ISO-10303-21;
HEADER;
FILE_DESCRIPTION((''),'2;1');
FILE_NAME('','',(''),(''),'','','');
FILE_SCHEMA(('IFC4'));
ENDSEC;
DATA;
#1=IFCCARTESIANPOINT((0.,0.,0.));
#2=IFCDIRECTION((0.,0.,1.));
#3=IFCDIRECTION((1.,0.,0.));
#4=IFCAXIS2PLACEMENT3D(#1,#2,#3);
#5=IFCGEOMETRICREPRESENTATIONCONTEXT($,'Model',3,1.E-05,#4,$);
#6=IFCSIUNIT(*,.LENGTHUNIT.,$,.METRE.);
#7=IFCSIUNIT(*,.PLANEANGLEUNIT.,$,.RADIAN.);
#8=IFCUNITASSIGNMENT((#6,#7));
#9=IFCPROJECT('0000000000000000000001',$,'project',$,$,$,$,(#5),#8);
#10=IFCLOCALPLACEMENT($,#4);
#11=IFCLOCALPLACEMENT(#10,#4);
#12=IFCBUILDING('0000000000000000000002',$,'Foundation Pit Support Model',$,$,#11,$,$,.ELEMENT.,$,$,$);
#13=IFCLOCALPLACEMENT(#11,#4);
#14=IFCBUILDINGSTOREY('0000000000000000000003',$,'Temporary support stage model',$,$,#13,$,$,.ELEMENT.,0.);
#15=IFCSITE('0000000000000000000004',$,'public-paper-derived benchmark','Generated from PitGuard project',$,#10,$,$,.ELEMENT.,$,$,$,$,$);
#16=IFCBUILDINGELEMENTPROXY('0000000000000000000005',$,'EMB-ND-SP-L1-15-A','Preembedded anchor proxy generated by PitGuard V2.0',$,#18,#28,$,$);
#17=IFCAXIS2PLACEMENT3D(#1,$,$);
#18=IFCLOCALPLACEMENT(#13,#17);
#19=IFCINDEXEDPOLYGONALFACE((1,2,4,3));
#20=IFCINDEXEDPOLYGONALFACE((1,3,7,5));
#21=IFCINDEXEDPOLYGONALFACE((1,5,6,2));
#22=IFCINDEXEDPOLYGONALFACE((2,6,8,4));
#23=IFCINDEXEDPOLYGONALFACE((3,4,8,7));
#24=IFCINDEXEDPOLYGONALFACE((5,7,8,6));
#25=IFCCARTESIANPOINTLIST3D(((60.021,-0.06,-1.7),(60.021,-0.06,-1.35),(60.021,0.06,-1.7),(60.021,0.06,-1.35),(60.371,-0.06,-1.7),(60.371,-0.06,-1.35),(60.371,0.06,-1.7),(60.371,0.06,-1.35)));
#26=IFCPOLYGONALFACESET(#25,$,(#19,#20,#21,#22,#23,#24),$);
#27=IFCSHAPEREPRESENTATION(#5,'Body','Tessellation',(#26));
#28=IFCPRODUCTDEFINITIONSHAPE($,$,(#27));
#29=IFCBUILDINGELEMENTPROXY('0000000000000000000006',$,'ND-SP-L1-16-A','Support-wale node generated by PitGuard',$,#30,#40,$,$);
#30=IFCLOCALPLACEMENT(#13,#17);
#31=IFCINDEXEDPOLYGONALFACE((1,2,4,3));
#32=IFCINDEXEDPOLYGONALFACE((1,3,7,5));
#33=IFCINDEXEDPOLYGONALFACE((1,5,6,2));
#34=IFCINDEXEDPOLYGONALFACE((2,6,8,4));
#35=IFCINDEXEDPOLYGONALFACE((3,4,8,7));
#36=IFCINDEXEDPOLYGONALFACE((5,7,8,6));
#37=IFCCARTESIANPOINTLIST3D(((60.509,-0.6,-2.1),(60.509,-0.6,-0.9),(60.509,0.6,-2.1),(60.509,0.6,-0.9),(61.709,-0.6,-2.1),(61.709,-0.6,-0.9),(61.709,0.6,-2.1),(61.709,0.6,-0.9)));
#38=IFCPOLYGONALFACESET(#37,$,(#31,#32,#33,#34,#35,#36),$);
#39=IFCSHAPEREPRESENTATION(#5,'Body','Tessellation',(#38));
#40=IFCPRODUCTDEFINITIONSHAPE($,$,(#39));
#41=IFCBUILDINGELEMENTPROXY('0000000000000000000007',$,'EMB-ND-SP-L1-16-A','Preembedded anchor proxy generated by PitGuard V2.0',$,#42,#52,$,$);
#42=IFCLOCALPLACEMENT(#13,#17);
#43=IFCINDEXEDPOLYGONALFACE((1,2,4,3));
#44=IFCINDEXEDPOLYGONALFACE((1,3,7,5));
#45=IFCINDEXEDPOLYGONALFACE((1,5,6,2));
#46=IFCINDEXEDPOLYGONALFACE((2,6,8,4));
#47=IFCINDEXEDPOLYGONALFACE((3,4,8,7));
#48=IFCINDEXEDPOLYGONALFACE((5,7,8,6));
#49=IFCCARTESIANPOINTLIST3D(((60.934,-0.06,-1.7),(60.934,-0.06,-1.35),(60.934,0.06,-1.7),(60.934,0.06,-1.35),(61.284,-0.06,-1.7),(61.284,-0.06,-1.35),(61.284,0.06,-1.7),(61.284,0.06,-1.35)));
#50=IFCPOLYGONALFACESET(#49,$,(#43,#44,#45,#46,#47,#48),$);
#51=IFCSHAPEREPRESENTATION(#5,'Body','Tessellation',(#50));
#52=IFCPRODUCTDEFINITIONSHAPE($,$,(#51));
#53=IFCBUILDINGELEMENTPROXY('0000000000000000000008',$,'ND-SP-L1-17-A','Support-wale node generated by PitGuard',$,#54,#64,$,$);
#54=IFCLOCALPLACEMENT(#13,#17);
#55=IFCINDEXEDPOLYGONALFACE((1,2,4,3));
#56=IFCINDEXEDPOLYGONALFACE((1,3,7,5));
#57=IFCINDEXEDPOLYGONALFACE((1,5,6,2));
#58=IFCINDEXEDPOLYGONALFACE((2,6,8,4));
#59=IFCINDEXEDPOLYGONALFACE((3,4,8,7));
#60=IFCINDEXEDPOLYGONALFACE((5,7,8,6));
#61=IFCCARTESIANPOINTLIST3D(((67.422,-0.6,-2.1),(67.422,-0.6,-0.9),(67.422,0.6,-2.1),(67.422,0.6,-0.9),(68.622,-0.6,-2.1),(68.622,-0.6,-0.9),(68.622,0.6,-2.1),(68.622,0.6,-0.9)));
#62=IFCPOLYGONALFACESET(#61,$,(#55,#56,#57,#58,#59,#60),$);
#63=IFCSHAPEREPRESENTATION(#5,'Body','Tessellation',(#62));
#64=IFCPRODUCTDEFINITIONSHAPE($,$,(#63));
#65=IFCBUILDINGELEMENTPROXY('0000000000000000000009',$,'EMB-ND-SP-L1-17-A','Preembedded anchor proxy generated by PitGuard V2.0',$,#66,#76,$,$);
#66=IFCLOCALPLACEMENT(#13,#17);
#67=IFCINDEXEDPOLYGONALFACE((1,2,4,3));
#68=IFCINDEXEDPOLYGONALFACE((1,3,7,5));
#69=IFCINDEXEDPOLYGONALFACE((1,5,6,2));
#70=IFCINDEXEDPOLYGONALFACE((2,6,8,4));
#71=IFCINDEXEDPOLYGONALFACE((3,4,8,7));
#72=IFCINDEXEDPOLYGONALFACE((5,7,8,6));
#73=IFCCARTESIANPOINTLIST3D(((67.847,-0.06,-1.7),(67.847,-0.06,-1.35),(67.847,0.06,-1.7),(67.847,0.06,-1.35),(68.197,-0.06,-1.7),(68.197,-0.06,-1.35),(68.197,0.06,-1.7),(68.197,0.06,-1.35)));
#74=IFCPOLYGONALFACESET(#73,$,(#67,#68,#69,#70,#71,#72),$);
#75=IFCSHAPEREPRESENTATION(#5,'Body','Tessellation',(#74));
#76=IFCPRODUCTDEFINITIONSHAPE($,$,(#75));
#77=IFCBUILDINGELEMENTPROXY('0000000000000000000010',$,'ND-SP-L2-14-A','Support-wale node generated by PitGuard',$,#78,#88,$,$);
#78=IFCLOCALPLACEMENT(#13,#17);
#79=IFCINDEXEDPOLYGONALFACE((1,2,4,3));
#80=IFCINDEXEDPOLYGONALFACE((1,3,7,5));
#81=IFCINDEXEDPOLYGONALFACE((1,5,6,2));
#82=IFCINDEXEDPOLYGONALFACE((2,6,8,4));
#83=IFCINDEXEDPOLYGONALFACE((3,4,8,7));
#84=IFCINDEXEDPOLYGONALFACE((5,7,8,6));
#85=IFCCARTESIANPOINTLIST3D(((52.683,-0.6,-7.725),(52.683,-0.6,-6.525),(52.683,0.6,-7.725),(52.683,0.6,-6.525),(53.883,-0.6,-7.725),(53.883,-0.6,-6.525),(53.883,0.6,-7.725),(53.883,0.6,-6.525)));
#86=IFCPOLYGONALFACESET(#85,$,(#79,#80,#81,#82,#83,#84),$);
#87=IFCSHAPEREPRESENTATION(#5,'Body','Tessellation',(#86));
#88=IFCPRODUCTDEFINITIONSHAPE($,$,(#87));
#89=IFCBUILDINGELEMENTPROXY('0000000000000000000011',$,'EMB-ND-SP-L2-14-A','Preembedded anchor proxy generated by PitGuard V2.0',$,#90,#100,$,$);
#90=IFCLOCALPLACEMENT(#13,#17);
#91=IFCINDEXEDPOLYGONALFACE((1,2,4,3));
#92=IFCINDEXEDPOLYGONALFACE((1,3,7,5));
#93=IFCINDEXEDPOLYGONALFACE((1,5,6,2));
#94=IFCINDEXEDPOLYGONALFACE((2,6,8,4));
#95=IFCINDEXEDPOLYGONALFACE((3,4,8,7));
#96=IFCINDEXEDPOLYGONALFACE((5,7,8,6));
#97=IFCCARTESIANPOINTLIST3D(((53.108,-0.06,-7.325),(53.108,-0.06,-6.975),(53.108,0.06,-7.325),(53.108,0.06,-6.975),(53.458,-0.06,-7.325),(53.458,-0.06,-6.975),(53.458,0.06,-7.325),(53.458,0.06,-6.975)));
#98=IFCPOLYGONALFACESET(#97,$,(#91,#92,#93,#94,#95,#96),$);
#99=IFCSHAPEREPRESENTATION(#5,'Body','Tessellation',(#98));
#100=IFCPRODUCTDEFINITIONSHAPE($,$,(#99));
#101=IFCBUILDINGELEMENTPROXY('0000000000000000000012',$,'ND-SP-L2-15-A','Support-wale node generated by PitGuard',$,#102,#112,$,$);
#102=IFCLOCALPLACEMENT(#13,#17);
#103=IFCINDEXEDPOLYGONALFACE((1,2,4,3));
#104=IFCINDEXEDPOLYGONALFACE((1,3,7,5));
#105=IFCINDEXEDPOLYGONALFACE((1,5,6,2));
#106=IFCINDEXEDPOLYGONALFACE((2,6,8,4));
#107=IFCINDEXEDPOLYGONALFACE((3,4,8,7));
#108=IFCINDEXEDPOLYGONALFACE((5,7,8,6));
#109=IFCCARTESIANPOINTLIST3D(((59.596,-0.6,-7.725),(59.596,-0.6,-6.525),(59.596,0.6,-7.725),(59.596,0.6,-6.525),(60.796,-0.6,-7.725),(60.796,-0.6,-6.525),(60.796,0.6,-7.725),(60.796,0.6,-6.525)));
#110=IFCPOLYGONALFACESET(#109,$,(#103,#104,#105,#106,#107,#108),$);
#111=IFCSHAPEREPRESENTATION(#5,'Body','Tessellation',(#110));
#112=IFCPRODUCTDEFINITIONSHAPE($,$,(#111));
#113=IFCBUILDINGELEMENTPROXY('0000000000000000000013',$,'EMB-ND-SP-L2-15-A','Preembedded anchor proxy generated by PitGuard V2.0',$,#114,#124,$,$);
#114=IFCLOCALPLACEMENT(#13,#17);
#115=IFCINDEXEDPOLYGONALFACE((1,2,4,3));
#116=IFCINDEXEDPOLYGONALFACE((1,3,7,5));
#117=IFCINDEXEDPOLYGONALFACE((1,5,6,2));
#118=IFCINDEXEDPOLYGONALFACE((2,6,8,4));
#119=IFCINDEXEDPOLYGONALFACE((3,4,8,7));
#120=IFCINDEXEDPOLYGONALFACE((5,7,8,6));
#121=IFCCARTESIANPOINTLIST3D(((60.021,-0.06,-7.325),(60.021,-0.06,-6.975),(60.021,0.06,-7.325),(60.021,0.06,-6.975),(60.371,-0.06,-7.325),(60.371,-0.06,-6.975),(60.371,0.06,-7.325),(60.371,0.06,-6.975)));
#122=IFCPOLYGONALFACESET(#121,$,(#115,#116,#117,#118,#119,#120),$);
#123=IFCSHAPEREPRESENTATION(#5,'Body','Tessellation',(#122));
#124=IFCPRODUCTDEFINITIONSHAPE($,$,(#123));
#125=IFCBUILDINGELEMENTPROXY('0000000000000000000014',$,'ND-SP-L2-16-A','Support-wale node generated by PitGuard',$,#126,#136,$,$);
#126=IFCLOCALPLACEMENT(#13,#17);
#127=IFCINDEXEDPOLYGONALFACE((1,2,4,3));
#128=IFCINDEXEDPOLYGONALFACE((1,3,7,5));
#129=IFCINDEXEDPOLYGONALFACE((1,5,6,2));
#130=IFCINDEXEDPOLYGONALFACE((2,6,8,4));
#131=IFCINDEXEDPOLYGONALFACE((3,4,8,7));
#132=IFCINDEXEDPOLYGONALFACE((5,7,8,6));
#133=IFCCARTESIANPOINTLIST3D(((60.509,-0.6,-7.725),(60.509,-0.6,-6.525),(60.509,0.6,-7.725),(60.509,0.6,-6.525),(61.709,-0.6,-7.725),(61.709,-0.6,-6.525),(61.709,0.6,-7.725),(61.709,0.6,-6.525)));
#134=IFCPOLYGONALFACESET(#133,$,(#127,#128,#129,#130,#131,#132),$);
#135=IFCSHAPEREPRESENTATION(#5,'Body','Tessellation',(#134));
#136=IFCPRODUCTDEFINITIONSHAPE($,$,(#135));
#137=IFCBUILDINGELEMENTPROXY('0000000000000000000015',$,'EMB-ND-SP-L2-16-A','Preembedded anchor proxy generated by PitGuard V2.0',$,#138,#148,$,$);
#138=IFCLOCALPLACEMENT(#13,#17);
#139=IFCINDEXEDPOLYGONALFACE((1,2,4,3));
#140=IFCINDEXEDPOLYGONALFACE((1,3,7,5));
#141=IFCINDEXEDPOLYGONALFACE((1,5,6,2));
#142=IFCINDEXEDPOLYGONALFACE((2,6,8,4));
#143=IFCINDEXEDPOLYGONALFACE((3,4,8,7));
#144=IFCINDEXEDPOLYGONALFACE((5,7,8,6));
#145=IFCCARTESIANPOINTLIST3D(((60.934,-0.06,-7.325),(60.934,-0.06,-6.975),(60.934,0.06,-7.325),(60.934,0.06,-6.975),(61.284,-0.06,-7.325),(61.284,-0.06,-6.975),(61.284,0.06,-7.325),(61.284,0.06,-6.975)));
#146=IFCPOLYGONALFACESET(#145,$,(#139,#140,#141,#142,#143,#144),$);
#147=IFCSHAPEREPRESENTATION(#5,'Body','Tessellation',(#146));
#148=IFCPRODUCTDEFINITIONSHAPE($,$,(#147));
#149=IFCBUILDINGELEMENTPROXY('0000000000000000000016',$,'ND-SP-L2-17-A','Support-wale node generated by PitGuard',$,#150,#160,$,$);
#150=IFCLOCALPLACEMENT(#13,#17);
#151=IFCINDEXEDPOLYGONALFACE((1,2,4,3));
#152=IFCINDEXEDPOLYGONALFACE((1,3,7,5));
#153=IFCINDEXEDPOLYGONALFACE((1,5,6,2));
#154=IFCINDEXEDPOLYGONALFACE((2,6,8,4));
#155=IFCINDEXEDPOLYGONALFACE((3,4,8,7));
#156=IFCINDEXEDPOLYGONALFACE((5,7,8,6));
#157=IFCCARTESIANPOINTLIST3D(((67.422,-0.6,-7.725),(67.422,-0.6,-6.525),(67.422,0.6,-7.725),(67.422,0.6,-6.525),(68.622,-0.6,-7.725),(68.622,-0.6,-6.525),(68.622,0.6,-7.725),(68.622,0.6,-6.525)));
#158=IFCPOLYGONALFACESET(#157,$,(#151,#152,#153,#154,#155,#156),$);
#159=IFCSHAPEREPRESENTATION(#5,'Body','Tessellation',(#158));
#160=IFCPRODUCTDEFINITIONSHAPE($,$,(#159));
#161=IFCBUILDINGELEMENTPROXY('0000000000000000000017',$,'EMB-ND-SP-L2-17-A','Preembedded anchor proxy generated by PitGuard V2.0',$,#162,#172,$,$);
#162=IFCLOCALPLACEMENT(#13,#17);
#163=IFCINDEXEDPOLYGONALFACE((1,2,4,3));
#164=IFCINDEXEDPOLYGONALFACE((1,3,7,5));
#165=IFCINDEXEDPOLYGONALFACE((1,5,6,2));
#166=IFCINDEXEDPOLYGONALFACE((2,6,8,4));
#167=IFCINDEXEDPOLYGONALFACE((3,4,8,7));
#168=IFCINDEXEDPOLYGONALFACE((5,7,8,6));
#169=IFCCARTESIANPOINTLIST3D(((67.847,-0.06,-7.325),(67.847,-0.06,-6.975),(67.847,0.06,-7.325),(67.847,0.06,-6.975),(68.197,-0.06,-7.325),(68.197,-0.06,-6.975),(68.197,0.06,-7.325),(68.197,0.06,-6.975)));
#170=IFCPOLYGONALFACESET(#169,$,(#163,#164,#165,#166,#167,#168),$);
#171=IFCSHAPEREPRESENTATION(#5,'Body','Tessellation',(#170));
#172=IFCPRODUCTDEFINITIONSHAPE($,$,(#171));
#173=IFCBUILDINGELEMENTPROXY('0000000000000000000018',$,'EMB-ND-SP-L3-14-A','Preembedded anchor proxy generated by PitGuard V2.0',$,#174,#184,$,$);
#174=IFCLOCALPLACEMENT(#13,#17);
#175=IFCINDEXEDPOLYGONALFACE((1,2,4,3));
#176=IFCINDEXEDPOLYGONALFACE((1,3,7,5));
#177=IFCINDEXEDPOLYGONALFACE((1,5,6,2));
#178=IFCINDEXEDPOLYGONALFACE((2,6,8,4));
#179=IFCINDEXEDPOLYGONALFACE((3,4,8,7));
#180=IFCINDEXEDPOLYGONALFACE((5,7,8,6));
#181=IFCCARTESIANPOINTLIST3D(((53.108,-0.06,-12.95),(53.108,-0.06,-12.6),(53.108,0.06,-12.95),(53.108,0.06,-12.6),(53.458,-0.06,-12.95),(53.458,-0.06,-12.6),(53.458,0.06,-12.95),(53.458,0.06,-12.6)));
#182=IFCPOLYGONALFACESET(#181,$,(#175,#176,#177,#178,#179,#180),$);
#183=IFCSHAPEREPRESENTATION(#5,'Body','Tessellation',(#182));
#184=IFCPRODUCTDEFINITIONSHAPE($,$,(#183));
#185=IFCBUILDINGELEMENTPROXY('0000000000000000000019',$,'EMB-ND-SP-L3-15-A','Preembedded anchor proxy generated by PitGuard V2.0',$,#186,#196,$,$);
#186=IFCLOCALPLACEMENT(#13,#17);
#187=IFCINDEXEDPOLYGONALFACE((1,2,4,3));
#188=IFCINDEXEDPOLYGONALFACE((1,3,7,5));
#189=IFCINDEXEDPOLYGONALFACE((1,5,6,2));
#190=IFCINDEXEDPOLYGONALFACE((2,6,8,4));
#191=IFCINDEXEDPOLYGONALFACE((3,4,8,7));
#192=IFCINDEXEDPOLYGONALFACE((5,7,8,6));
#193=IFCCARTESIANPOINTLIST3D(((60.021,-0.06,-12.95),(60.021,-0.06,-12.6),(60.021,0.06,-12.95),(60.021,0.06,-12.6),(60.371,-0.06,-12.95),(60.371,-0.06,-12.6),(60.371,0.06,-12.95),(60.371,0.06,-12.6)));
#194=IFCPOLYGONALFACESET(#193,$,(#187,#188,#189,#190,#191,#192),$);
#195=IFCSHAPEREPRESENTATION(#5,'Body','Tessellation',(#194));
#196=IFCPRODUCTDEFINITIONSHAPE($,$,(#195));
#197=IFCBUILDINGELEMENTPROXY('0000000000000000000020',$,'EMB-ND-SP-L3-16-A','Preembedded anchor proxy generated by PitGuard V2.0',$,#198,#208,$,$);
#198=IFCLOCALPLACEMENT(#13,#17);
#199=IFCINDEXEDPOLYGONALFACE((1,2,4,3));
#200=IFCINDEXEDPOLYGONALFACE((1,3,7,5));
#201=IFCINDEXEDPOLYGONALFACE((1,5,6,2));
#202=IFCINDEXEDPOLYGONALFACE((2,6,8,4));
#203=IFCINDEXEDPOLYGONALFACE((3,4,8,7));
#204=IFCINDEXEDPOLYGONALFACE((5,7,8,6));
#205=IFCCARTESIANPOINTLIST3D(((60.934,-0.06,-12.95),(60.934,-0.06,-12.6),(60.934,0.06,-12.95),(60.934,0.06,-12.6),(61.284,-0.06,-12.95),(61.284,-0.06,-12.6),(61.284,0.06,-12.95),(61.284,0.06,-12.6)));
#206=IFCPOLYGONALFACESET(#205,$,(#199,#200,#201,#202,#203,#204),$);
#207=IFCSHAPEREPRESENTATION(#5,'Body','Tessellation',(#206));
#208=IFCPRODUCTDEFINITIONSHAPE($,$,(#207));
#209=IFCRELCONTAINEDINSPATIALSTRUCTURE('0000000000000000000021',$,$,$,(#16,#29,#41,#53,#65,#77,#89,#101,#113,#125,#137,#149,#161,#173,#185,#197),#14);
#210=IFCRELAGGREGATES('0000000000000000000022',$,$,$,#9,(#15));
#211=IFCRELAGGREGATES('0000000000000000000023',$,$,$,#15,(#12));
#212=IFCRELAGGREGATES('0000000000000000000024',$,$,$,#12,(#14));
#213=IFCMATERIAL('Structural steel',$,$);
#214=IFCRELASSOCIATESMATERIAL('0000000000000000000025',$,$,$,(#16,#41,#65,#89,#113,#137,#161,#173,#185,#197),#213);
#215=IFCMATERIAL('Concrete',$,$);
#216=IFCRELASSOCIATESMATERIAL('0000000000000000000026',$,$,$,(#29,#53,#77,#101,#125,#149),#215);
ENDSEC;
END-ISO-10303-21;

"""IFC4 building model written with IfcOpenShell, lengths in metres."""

from ifc_helpers import new_model, si_unit, frame, origin_with_axes, origin_2d, place, context, project, spatial, rectangle, extrude, material, element, save


model = new_model("IFC4")

# Units and contexts
model_context = context("Model", 3, precision=1e-05, world=origin_with_axes())
ifc_project = project(units=[si_unit("LENGTHUNIT", "METRE"), si_unit("PLANEANGLEUNIT", "RADIAN")], contexts=[model_context])

# Site, building, storey
site_placement = place(None, origin_with_axes())
site = spatial("IfcSite", under=ifc_project, at=site_placement, Name="public-paper-derived benchmark", Description="Generated from PitGuard project", CompositionType="ELEMENT")
building_placement = place(site_placement, origin_with_axes())
building = spatial("IfcBuilding", under=site, at=building_placement, Name="Foundation Pit Support Model", CompositionType="ELEMENT")
storey_placement = place(building_placement, origin_with_axes())
storey = spatial("IfcBuildingStorey", under=building, at=storey_placement, Name="Temporary support stage model", CompositionType="ELEMENT", Elevation=0.0)

# Shared definitions
ifc_material_1 = material(Name="Concrete")

# Shared definitions
ifc_material_2 = material(Name="Structural steel")

# Building element proxies
proxy_1_placement = place(storey_placement, frame((60.196, 0.0, -1.7), z_axis=(0.0, 0.0, 1.0), x_axis=(1.0, 0.0, 0.0)))
element("IfcBuildingElementProxy", 1, at=proxy_1_placement, inside=storey, material=ifc_material_2, Name="EMB-ND-SP-L1-15-A", Description="Preembedded anchor proxy generated by PitGuard V2.0", context=model_context, shape_type="SweptSolid", body=[
    extrude(rectangle(XDim=0.35, YDim=0.12, at=origin_2d()), origin_with_axes(), (0.0, 0.0, 1.0), 0.35),
])
proxy_2_placement = place(storey_placement, frame((61.109, 0.0, -2.1), z_axis=(0.0, 0.0, 1.0), x_axis=(1.0, 0.0, 0.0)))
element("IfcBuildingElementProxy", 2, at=proxy_2_placement, inside=storey, material=ifc_material_1, Name="ND-SP-L1-16-A", Description="Support-wale node generated by PitGuard", context=model_context, shape_type="SweptSolid", body=[
    extrude(rectangle(XDim=1.2, YDim=1.2, at=origin_2d()), origin_with_axes(), (0.0, 0.0, 1.0), 1.2),
])
proxy_3_placement = place(storey_placement, frame((61.109, 0.0, -1.7), z_axis=(0.0, 0.0, 1.0), x_axis=(1.0, 0.0, 0.0)))
element("IfcBuildingElementProxy", 3, at=proxy_3_placement, inside=storey, material=ifc_material_2, Name="EMB-ND-SP-L1-16-A", Description="Preembedded anchor proxy generated by PitGuard V2.0", context=model_context, shape_type="SweptSolid", body=[
    extrude(rectangle(XDim=0.35, YDim=0.12, at=origin_2d()), origin_with_axes(), (0.0, 0.0, 1.0), 0.35),
])
proxy_4_placement = place(storey_placement, frame((68.022, 0.0, -2.1), z_axis=(0.0, 0.0, 1.0), x_axis=(1.0, 0.0, 0.0)))
element("IfcBuildingElementProxy", 4, at=proxy_4_placement, inside=storey, material=ifc_material_1, Name="ND-SP-L1-17-A", Description="Support-wale node generated by PitGuard", context=model_context, shape_type="SweptSolid", body=[
    extrude(rectangle(XDim=1.2, YDim=1.2, at=origin_2d()), origin_with_axes(), (0.0, 0.0, 1.0), 1.2),
])
proxy_5_placement = place(storey_placement, frame((68.022, 0.0, -1.7), z_axis=(0.0, 0.0, 1.0), x_axis=(1.0, 0.0, 0.0)))
element("IfcBuildingElementProxy", 5, at=proxy_5_placement, inside=storey, material=ifc_material_2, Name="EMB-ND-SP-L1-17-A", Description="Preembedded anchor proxy generated by PitGuard V2.0", context=model_context, shape_type="SweptSolid", body=[
    extrude(rectangle(XDim=0.35, YDim=0.12, at=origin_2d()), origin_with_axes(), (0.0, 0.0, 1.0), 0.35),
])
proxy_6_placement = place(storey_placement, frame((53.283, 0.0, -7.725), z_axis=(0.0, 0.0, 1.0), x_axis=(1.0, 0.0, 0.0)))
element("IfcBuildingElementProxy", 6, at=proxy_6_placement, inside=storey, material=ifc_material_1, Name="ND-SP-L2-14-A", Description="Support-wale node generated by PitGuard", context=model_context, shape_type="SweptSolid", body=[
    extrude(rectangle(XDim=1.2, YDim=1.2, at=origin_2d()), origin_with_axes(), (0.0, 0.0, 1.0), 1.2),
])
proxy_7_placement = place(storey_placement, frame((53.283, 0.0, -7.325), z_axis=(0.0, 0.0, 1.0), x_axis=(1.0, 0.0, 0.0)))
element("IfcBuildingElementProxy", 7, at=proxy_7_placement, inside=storey, material=ifc_material_2, Name="EMB-ND-SP-L2-14-A", Description="Preembedded anchor proxy generated by PitGuard V2.0", context=model_context, shape_type="SweptSolid", body=[
    extrude(rectangle(XDim=0.35, YDim=0.12, at=origin_2d()), origin_with_axes(), (0.0, 0.0, 1.0), 0.35),
])
proxy_8_placement = place(storey_placement, frame((60.196, 0.0, -7.725), z_axis=(0.0, 0.0, 1.0), x_axis=(1.0, 0.0, 0.0)))
element("IfcBuildingElementProxy", 8, at=proxy_8_placement, inside=storey, material=ifc_material_1, Name="ND-SP-L2-15-A", Description="Support-wale node generated by PitGuard", context=model_context, shape_type="SweptSolid", body=[
    extrude(rectangle(XDim=1.2, YDim=1.2, at=origin_2d()), origin_with_axes(), (0.0, 0.0, 1.0), 1.2),
])
proxy_9_placement = place(storey_placement, frame((60.196, 0.0, -7.325), z_axis=(0.0, 0.0, 1.0), x_axis=(1.0, 0.0, 0.0)))
element("IfcBuildingElementProxy", 9, at=proxy_9_placement, inside=storey, material=ifc_material_2, Name="EMB-ND-SP-L2-15-A", Description="Preembedded anchor proxy generated by PitGuard V2.0", context=model_context, shape_type="SweptSolid", body=[
    extrude(rectangle(XDim=0.35, YDim=0.12, at=origin_2d()), origin_with_axes(), (0.0, 0.0, 1.0), 0.35),
])
proxy_10_placement = place(storey_placement, frame((61.109, 0.0, -7.725), z_axis=(0.0, 0.0, 1.0), x_axis=(1.0, 0.0, 0.0)))
element("IfcBuildingElementProxy", 10, at=proxy_10_placement, inside=storey, material=ifc_material_1, Name="ND-SP-L2-16-A", Description="Support-wale node generated by PitGuard", context=model_context, shape_type="SweptSolid", body=[
    extrude(rectangle(XDim=1.2, YDim=1.2, at=origin_2d()), origin_with_axes(), (0.0, 0.0, 1.0), 1.2),
])
proxy_11_placement = place(storey_placement, frame((61.109, 0.0, -7.325), z_axis=(0.0, 0.0, 1.0), x_axis=(1.0, 0.0, 0.0)))
element("IfcBuildingElementProxy", 11, at=proxy_11_placement, inside=storey, material=ifc_material_2, Name="EMB-ND-SP-L2-16-A", Description="Preembedded anchor proxy generated by PitGuard V2.0", context=model_context, shape_type="SweptSolid", body=[
    extrude(rectangle(XDim=0.35, YDim=0.12, at=origin_2d()), origin_with_axes(), (0.0, 0.0, 1.0), 0.35),
])
proxy_12_placement = place(storey_placement, frame((68.022, 0.0, -7.725), z_axis=(0.0, 0.0, 1.0), x_axis=(1.0, 0.0, 0.0)))
element("IfcBuildingElementProxy", 12, at=proxy_12_placement, inside=storey, material=ifc_material_1, Name="ND-SP-L2-17-A", Description="Support-wale node generated by PitGuard", context=model_context, shape_type="SweptSolid", body=[
    extrude(rectangle(XDim=1.2, YDim=1.2, at=origin_2d()), origin_with_axes(), (0.0, 0.0, 1.0), 1.2),
])
for number, where, z_axis, x_axis, name in (
    (13, (68.022, 0.0, -7.325), (0.0, 0.0, 1.0), (1.0, 0.0, 0.0), "EMB-ND-SP-L2-17-A"),
    (14, (53.283, 0.0, -12.95), (0.0, 0.0, 1.0), (1.0, 0.0, 0.0), "EMB-ND-SP-L3-14-A"),
    (15, (60.196, 0.0, -12.95), (0.0, 0.0, 1.0), (1.0, 0.0, 0.0), "EMB-ND-SP-L3-15-A"),
    (16, (61.109, 0.0, -12.95), (0.0, 0.0, 1.0), (1.0, 0.0, 0.0), "EMB-ND-SP-L3-16-A"),
):
    element("IfcBuildingElementProxy", number, at=place(storey_placement, frame(where, z_axis=z_axis, x_axis=x_axis)), inside=storey, material=ifc_material_2, Name=name, Description="Preembedded anchor proxy generated by PitGuard V2.0", context=model_context, shape_type="SweptSolid", body=[
        extrude(rectangle(XDim=0.35, YDim=0.12, at=origin_2d()), origin_with_axes(), (0.0, 0.0, 1.0), 0.35),
    ])

save(model, "model.ifc")
